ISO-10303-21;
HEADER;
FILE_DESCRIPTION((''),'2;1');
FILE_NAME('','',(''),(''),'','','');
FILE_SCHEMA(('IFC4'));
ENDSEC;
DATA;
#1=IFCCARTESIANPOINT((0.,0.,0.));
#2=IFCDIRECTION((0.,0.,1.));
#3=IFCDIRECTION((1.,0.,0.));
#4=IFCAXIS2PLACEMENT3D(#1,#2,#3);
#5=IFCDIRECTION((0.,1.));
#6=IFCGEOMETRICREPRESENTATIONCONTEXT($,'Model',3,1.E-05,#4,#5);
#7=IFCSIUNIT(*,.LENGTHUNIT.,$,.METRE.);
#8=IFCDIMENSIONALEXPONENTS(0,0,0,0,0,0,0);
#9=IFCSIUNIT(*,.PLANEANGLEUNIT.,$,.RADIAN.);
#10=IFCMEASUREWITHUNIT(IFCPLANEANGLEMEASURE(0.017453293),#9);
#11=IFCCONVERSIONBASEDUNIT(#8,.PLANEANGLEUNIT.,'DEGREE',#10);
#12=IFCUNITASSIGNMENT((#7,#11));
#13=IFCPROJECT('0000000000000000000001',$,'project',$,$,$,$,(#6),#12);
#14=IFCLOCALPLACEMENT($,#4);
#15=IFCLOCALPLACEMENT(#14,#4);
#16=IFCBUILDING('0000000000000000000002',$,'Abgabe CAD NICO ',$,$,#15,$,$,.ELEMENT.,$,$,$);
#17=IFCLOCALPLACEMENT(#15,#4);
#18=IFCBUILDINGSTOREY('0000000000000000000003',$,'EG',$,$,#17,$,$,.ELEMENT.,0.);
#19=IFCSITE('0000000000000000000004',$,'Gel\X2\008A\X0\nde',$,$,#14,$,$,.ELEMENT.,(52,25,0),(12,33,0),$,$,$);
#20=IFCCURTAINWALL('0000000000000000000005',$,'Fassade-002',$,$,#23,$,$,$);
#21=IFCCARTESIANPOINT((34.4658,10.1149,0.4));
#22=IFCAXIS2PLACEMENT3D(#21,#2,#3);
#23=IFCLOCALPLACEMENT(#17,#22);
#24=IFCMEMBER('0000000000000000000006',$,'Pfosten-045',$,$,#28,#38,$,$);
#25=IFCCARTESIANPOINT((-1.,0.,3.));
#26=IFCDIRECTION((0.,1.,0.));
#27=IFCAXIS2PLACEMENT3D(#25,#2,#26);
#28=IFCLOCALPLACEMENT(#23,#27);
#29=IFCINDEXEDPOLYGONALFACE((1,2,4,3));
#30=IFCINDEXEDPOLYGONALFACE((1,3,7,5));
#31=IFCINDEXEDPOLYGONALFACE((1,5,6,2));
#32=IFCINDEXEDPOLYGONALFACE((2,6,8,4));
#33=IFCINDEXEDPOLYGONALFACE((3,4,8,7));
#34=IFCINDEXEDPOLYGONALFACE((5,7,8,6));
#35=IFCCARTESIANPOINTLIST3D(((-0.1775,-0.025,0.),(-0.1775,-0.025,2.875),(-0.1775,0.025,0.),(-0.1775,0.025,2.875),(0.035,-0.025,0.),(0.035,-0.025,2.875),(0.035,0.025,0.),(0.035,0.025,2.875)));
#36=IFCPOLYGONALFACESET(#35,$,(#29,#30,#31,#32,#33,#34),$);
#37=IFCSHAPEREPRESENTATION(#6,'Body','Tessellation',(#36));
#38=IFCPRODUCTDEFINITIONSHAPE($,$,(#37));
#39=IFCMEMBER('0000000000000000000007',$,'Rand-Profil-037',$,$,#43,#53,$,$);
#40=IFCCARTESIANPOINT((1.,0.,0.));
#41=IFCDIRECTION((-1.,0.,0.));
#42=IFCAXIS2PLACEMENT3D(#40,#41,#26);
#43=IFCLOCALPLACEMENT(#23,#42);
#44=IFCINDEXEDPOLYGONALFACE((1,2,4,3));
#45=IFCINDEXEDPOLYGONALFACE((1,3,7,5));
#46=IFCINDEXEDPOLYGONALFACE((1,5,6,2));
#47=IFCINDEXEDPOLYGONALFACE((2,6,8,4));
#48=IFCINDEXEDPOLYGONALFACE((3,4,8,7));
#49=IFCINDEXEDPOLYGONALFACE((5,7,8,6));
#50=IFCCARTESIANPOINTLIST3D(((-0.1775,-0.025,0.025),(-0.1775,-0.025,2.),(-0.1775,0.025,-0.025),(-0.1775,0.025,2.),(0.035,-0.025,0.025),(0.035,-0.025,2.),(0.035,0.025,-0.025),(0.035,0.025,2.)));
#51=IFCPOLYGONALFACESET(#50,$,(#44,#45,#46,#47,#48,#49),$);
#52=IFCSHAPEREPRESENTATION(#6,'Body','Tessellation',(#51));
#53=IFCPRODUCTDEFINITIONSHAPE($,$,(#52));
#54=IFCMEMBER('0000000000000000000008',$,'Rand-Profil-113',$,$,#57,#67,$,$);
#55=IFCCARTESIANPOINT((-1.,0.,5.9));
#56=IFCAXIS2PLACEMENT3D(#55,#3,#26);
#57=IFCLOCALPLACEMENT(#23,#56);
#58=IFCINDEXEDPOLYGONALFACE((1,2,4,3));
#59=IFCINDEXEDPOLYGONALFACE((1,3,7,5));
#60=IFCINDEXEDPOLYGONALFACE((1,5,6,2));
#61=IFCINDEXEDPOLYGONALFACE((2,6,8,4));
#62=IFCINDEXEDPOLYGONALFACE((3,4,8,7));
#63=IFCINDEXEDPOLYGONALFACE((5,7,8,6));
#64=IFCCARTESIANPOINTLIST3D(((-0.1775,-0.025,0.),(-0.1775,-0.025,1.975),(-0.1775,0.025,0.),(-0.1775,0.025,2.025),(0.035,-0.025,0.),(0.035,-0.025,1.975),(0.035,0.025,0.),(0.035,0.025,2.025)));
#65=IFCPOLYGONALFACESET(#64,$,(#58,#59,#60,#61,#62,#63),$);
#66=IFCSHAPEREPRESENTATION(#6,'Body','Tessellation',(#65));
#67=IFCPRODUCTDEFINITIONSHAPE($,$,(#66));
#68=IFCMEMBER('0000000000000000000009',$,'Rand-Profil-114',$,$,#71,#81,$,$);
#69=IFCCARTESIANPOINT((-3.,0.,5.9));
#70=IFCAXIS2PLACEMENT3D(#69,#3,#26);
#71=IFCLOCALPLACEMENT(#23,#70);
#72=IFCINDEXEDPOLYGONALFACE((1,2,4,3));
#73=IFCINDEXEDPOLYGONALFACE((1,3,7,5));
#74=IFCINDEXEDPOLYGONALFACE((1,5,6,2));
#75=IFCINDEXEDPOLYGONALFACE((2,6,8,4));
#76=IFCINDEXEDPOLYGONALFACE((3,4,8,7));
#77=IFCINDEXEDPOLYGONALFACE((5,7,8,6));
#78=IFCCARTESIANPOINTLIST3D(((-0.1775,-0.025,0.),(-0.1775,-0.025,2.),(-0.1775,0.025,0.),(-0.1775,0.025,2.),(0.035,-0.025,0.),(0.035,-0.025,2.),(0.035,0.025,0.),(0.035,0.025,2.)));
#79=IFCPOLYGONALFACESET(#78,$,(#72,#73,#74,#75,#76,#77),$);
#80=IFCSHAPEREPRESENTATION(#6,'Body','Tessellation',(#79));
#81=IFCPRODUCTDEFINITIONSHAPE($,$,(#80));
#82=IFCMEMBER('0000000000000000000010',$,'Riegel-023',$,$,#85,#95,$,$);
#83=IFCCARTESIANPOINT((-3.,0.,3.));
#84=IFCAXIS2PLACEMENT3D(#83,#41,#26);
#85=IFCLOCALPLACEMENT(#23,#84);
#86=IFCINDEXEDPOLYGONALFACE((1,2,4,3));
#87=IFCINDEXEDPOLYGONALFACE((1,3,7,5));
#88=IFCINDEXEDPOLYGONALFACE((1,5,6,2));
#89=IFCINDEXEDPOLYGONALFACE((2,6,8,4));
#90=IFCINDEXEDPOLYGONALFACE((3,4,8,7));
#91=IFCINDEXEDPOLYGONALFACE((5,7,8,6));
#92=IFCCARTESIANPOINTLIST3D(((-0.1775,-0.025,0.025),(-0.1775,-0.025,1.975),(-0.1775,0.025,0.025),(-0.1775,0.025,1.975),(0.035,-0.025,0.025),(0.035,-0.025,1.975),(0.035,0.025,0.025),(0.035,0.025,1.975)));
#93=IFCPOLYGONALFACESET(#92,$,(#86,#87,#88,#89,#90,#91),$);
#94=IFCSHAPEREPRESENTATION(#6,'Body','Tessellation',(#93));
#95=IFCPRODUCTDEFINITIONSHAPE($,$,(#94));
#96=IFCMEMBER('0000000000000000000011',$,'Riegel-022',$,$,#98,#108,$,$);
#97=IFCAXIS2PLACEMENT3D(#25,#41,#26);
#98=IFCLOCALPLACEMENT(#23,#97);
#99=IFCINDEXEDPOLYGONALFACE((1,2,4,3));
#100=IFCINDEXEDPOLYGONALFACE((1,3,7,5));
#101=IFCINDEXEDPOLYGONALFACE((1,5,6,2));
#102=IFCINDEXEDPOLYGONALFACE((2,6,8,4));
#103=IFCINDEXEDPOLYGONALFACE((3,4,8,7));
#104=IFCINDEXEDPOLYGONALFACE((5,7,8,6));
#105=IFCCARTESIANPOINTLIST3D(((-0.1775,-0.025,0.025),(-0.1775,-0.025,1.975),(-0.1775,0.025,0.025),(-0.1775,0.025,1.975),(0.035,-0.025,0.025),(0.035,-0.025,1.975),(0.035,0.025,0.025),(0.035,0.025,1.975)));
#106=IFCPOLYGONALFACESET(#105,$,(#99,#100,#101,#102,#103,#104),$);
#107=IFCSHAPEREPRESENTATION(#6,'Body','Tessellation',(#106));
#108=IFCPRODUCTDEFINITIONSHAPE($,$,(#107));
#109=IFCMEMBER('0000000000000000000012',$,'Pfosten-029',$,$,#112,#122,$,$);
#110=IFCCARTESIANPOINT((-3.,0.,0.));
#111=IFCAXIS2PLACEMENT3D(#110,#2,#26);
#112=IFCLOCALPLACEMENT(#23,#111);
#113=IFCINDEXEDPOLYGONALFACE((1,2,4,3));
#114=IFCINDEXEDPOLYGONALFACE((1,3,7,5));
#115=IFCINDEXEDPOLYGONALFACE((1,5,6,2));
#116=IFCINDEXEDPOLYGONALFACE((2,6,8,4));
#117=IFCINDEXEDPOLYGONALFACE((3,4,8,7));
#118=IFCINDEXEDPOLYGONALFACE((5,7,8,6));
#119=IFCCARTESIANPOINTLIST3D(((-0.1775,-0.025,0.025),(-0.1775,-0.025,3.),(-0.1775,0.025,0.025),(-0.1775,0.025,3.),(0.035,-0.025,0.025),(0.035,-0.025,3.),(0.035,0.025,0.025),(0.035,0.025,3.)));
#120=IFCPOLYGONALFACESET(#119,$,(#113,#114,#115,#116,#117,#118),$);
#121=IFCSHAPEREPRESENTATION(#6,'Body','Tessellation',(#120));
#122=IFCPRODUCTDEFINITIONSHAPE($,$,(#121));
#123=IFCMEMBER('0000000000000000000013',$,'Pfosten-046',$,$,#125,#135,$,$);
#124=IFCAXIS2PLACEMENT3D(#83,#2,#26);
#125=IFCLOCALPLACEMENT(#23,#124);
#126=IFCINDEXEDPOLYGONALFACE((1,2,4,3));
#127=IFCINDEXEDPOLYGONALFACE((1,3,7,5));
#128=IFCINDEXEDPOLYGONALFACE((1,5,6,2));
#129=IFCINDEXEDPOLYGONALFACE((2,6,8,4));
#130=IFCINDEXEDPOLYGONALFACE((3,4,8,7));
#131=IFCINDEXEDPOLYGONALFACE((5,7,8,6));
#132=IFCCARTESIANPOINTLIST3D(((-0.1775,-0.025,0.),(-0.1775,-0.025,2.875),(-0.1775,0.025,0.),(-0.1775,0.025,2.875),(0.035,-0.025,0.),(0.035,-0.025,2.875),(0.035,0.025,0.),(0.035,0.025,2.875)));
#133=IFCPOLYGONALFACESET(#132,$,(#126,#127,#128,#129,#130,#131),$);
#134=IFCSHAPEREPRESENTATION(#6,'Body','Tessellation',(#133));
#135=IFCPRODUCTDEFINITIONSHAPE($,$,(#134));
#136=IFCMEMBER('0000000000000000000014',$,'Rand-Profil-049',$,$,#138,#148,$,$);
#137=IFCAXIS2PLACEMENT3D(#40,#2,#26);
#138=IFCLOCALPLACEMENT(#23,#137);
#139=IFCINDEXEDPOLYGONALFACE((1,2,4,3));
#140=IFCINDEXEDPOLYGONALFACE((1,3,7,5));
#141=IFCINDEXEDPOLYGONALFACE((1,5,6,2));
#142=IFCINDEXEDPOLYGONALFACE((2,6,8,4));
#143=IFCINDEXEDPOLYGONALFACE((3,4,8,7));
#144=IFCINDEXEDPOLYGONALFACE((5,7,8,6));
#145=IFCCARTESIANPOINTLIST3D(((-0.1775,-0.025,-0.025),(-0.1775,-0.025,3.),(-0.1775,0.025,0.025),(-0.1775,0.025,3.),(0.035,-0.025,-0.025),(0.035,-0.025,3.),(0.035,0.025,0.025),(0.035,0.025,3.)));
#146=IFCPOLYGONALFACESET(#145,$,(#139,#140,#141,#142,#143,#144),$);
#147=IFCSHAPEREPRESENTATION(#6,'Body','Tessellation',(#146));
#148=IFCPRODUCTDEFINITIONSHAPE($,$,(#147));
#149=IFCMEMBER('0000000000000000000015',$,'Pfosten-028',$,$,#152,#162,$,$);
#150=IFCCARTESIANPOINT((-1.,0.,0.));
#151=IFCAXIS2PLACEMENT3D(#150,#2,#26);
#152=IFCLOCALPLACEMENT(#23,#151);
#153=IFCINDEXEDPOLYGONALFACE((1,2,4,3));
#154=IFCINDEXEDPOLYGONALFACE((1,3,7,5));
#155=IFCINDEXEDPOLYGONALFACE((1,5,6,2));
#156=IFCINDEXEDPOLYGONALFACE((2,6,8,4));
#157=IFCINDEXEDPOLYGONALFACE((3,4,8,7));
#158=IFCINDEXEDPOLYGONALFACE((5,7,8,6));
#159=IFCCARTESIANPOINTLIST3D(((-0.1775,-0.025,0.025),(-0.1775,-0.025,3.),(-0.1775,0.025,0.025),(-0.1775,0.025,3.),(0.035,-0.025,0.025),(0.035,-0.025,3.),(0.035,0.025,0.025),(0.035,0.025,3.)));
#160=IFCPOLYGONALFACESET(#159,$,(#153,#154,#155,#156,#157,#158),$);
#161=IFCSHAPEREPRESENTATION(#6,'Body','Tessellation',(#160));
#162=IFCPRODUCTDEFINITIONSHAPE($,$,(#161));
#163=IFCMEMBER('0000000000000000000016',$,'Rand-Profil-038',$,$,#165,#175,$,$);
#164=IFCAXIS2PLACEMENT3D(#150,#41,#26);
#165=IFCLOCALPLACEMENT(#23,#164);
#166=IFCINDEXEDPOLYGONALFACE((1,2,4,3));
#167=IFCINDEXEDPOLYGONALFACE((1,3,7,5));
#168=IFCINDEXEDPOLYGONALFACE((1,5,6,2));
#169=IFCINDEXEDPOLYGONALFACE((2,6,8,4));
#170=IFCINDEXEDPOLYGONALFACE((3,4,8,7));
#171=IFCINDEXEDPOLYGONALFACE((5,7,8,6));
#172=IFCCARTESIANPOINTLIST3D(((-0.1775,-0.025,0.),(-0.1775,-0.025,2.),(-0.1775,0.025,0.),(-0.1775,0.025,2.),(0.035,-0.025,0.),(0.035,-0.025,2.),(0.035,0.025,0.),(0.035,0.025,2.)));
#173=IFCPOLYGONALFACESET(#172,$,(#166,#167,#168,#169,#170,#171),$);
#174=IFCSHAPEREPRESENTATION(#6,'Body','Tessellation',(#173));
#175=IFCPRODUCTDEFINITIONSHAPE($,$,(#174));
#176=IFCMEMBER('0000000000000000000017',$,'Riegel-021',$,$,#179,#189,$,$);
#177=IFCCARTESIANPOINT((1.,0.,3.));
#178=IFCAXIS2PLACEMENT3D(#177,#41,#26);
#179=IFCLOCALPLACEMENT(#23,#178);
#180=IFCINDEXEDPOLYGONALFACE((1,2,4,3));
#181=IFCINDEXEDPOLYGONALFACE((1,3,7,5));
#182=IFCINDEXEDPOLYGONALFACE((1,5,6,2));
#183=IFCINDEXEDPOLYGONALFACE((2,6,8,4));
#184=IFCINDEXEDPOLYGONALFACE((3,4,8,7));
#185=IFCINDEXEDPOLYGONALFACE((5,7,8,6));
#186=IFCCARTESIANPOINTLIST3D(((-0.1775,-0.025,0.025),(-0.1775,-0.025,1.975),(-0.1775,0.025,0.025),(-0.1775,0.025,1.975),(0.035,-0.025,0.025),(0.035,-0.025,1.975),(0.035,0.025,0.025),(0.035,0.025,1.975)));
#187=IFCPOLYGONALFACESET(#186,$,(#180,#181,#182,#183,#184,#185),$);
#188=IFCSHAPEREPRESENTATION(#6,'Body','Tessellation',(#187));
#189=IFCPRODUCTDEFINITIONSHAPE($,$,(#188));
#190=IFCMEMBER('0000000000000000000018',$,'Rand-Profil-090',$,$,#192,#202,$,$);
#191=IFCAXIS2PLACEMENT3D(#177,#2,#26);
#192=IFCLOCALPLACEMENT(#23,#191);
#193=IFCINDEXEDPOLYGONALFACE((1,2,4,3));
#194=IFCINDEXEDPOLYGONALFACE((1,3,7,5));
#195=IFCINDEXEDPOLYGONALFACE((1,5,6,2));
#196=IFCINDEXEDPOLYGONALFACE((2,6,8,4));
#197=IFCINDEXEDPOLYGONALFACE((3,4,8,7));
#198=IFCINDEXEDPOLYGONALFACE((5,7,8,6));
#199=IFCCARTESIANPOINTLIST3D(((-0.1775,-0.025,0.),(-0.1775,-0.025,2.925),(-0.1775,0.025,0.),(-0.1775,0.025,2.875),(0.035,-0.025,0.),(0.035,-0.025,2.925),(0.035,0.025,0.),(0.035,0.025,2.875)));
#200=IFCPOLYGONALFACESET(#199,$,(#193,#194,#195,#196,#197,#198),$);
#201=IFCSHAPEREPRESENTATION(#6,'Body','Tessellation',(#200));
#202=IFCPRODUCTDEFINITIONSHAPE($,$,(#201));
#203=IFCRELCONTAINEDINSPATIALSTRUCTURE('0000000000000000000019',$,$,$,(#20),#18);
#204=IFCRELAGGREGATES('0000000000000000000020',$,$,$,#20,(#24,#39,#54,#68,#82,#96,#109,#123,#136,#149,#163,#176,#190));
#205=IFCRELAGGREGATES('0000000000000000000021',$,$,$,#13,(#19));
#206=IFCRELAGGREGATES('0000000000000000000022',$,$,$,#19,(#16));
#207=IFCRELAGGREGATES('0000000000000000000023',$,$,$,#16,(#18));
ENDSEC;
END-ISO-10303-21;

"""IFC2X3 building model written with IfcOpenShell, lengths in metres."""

from ifc_helpers import new_model, entity, si_unit, converted_unit, direction, frame, origin_with_axes, place, context, project, spatial, polyline, outline, extrude, clip, halfspace, element, aggregate, save


model = new_model("IFC2X3")

# Units and contexts
model_context = context("Model", 3, precision=1e-05, world=origin_with_axes(), true_north=direction((0.0, 1.0)))
ifc_project = project(units=[si_unit("LENGTHUNIT", "METRE"), converted_unit("PLANEANGLEUNIT", "DEGREE", entity("IfcPlaneAngleMeasure", 0.017453293), si_unit("PLANEANGLEUNIT", "RADIAN"), dimensions=[0, 0, 0, 0, 0, 0, 0])], contexts=[model_context])

# Site, building, storey
site_placement = place(None, origin_with_axes())
site = spatial("IfcSite", under=ifc_project, at=site_placement, Name="Gel\u008ande", CompositionType="ELEMENT", RefLatitude=(52, 25, 0), RefLongitude=(12, 33, 0))
building_placement = place(site_placement, origin_with_axes())
building = spatial("IfcBuilding", under=site, at=building_placement, Name="Abgabe CAD NICO ", CompositionType="ELEMENT")
storey_placement = place(building_placement, origin_with_axes())
storey = spatial("IfcBuildingStorey", under=building, at=storey_placement, Name="EG", CompositionType="ELEMENT", Elevation=0.0)

# Curtain wall, members
curtain_wall_placement = place(storey_placement, frame((34.4658, 10.1149, 0.4), z_axis=(0.0, 0.0, 1.0), x_axis=(1.0, 0.0, 0.0)))
curtain_wall = element("IfcCurtainWall", 1, at=curtain_wall_placement, inside=storey, Name="Fassade-002")
member_1_placement = place(curtain_wall_placement, frame((-1.0, 0.0, 3.0), z_axis=(0.0, 0.0, 1.0), x_axis=(0.0, 1.0, 0.0)))
member_1 = element("IfcMember", 2, at=member_1_placement, Name="Pfosten-045", context=model_context, shape_type="SweptSolid", body=[
    extrude(outline(polyline([(0.025, -0.1775), (0.025, 0.035), (-0.025, 0.035), (-0.025, -0.1775), (0.025, -0.1775)])), frame((0.0, 0.0, 0.0), z_axis=(0.0, 0.0, 1.0), x_axis=(0.0, -1.0, 0.0)), (0.0, 0.0, 1.0), 2.875),
])
member_2_placement = place(curtain_wall_placement, frame((1.0, 0.0, 0.0), z_axis=(-1.0, 0.0, 0.0), x_axis=(0.0, 1.0, 0.0)))
member_2 = element("IfcMember", 3, at=member_2_placement, Name="Rand-Profil-037", context=model_context, shape_type="Clipping", body=[
    clip(extrude(outline(polyline([(-0.1775, -0.025), (0.035, -0.025), (0.035, 0.025), (-0.1775, 0.025), (-0.1775, -0.025)])), frame((0.0, 0.0, -0.025), z_axis=(0.0, 0.0, 1.0), x_axis=(1.0, 0.0, 0.0)), (0.0, 0.0, 1.0), 2.025), halfspace(frame((0.0, 0.0, 0.0), z_axis=(0.0, 0.707107, 0.707107), x_axis=(0.0, 0.707107, -0.707107)), True)),
])
member_3_placement = place(curtain_wall_placement, frame((-1.0, 0.0, 5.9), z_axis=(1.0, 0.0, 0.0), x_axis=(0.0, 1.0, 0.0)))
member_3 = element("IfcMember", 4, at=member_3_placement, Name="Rand-Profil-113", context=model_context, shape_type="Clipping", body=[
    clip(extrude(outline(polyline([(0.1775, 0.025), (-0.035, 0.025), (-0.035, -0.025), (0.1775, -0.025), (0.1775, 0.025)])), frame((0.0, 0.0, 0.0), z_axis=(0.0, 0.0, 1.0), x_axis=(-1.0, 0.0, 0.0)), (0.0, 0.0, 1.0), 2.025), halfspace(frame((0.0, -1.0, 1.0), z_axis=(0.0, 0.707107, -0.707107), x_axis=(0.0, -0.707107, -0.707107)), True)),
])
member_4_placement = place(curtain_wall_placement, frame((-3.0, 0.0, 5.9), z_axis=(1.0, 0.0, 0.0), x_axis=(0.0, 1.0, 0.0)))
member_4 = element("IfcMember", 5, at=member_4_placement, Name="Rand-Profil-114", context=model_context, shape_type="SweptSolid", body=[
    extrude(outline(polyline([(0.1775, 0.025), (-0.035, 0.025), (-0.035, -0.025), (0.1775, -0.025), (0.1775, 0.025)])), frame((0.0, 0.0, 0.0), z_axis=(0.0, 0.0, 1.0), x_axis=(-1.0, 0.0, 0.0)), (0.0, 0.0, 1.0), 2.0),
])
member_5_placement = place(curtain_wall_placement, frame((-3.0, 0.0, 3.0), z_axis=(-1.0, 0.0, 0.0), x_axis=(0.0, 1.0, 0.0)))
member_5 = element("IfcMember", 6, at=member_5_placement, Name="Riegel-023", context=model_context, shape_type="SweptSolid", body=[
    extrude(outline(polyline([(-0.1775, -0.025), (0.035, -0.025), (0.035, 0.025), (-0.1775, 0.025), (-0.1775, -0.025)])), frame((0.0, 0.0, 0.025), z_axis=(0.0, 0.0, 1.0), x_axis=(1.0, 0.0, 0.0)), (0.0, 0.0, 1.0), 1.95),
])
member_6_placement = place(curtain_wall_placement, frame((-1.0, 0.0, 3.0), z_axis=(-1.0, 0.0, 0.0), x_axis=(0.0, 1.0, 0.0)))
member_6 = element("IfcMember", 7, at=member_6_placement, Name="Riegel-022", context=model_context, shape_type="SweptSolid", body=[
    extrude(outline(polyline([(-0.1775, -0.025), (0.035, -0.025), (0.035, 0.025), (-0.1775, 0.025), (-0.1775, -0.025)])), frame((0.0, 0.0, 0.025), z_axis=(0.0, 0.0, 1.0), x_axis=(1.0, 0.0, 0.0)), (0.0, 0.0, 1.0), 1.95),
])
member_7_placement = place(curtain_wall_placement, frame((-3.0, 0.0, 0.0), z_axis=(0.0, 0.0, 1.0), x_axis=(0.0, 1.0, 0.0)))
member_7 = element("IfcMember", 8, at=member_7_placement, Name="Pfosten-029", context=model_context, shape_type="SweptSolid", body=[
    extrude(outline(polyline([(0.025, -0.1775), (0.025, 0.035), (-0.025, 0.035), (-0.025, -0.1775), (0.025, -0.1775)])), frame((0.0, 0.0, 0.025), z_axis=(0.0, 0.0, 1.0), x_axis=(0.0, -1.0, 0.0)), (0.0, 0.0, 1.0), 2.975),
])
member_8_placement = place(curtain_wall_placement, frame((-3.0, 0.0, 3.0), z_axis=(0.0, 0.0, 1.0), x_axis=(0.0, 1.0, 0.0)))
member_8 = element("IfcMember", 9, at=member_8_placement, Name="Pfosten-046", context=model_context, shape_type="SweptSolid", body=[
    extrude(outline(polyline([(0.025, -0.1775), (0.025, 0.035), (-0.025, 0.035), (-0.025, -0.1775), (0.025, -0.1775)])), frame((0.0, 0.0, 0.0), z_axis=(0.0, 0.0, 1.0), x_axis=(0.0, -1.0, 0.0)), (0.0, 0.0, 1.0), 2.875),
])
member_9_placement = place(curtain_wall_placement, frame((1.0, 0.0, 0.0), z_axis=(0.0, 0.0, 1.0), x_axis=(0.0, 1.0, 0.0)))
member_9 = element("IfcMember", 10, at=member_9_placement, Name="Rand-Profil-049", context=model_context, shape_type="Clipping", body=[
    clip(extrude(outline(polyline([(0.025, -0.1775), (0.025, 0.035), (-0.025, 0.035), (-0.025, -0.1775), (0.025, -0.1775)])), frame((0.0, 0.0, -0.025), z_axis=(0.0, 0.0, 1.0), x_axis=(0.0, -1.0, 0.0)), (0.0, 0.0, 1.0), 3.025), halfspace(frame((0.0, 0.0, 0.0), z_axis=(0.0, -0.707107, 0.707107), x_axis=(0.0, 0.707107, 0.707107)), True)),
])
member_10_placement = place(curtain_wall_placement, frame((-1.0, 0.0, 0.0), z_axis=(0.0, 0.0, 1.0), x_axis=(0.0, 1.0, 0.0)))
member_10 = element("IfcMember", 11, at=member_10_placement, Name="Pfosten-028", context=model_context, shape_type="SweptSolid", body=[
    extrude(outline(polyline([(0.025, -0.1775), (0.025, 0.035), (-0.025, 0.035), (-0.025, -0.1775), (0.025, -0.1775)])), frame((0.0, 0.0, 0.025), z_axis=(0.0, 0.0, 1.0), x_axis=(0.0, -1.0, 0.0)), (0.0, 0.0, 1.0), 2.975),
])
member_11_placement = place(curtain_wall_placement, frame((-1.0, 0.0, 0.0), z_axis=(-1.0, 0.0, 0.0), x_axis=(0.0, 1.0, 0.0)))
member_11 = element("IfcMember", 12, at=member_11_placement, Name="Rand-Profil-038", context=model_context, shape_type="SweptSolid", body=[
    extrude(outline(polyline([(-0.1775, -0.025), (0.035, -0.025), (0.035, 0.025), (-0.1775, 0.025), (-0.1775, -0.025)])), origin_with_axes(), (0.0, 0.0, 1.0), 2.0),
])
member_12_placement = place(curtain_wall_placement, frame((1.0, 0.0, 3.0), z_axis=(-1.0, 0.0, 0.0), x_axis=(0.0, 1.0, 0.0)))
member_12 = element("IfcMember", 13, at=member_12_placement, Name="Riegel-021", context=model_context, shape_type="SweptSolid", body=[
    extrude(outline(polyline([(-0.1775, -0.025), (0.035, -0.025), (0.035, 0.025), (-0.1775, 0.025), (-0.1775, -0.025)])), frame((0.0, 0.0, 0.025), z_axis=(0.0, 0.0, 1.0), x_axis=(1.0, 0.0, 0.0)), (0.0, 0.0, 1.0), 1.95),
])
member_13_placement = place(curtain_wall_placement, frame((1.0, 0.0, 3.0), z_axis=(0.0, 0.0, 1.0), x_axis=(0.0, 1.0, 0.0)))
member_13 = element("IfcMember", 14, at=member_13_placement, Name="Rand-Profil-090", context=model_context, shape_type="Clipping", body=[
    clip(extrude(outline(polyline([(0.025, -0.1775), (0.025, 0.035), (-0.025, 0.035), (-0.025, -0.1775), (0.025, -0.1775)])), frame((0.0, 0.0, 0.0), z_axis=(0.0, 0.0, 1.0), x_axis=(0.0, -1.0, 0.0)), (0.0, 0.0, 1.0), 2.925), halfspace(frame((0.0, 1.45, 1.45), z_axis=(0.0, -0.707107, -0.707107), x_axis=(0.0, -0.707107, 0.707107)), True)),
])

aggregate(curtain_wall, [member_1, member_2, member_3, member_4, member_5, member_6, member_7, member_8, member_9, member_10, member_11, member_12, member_13])

save(model, "model.ifc")
